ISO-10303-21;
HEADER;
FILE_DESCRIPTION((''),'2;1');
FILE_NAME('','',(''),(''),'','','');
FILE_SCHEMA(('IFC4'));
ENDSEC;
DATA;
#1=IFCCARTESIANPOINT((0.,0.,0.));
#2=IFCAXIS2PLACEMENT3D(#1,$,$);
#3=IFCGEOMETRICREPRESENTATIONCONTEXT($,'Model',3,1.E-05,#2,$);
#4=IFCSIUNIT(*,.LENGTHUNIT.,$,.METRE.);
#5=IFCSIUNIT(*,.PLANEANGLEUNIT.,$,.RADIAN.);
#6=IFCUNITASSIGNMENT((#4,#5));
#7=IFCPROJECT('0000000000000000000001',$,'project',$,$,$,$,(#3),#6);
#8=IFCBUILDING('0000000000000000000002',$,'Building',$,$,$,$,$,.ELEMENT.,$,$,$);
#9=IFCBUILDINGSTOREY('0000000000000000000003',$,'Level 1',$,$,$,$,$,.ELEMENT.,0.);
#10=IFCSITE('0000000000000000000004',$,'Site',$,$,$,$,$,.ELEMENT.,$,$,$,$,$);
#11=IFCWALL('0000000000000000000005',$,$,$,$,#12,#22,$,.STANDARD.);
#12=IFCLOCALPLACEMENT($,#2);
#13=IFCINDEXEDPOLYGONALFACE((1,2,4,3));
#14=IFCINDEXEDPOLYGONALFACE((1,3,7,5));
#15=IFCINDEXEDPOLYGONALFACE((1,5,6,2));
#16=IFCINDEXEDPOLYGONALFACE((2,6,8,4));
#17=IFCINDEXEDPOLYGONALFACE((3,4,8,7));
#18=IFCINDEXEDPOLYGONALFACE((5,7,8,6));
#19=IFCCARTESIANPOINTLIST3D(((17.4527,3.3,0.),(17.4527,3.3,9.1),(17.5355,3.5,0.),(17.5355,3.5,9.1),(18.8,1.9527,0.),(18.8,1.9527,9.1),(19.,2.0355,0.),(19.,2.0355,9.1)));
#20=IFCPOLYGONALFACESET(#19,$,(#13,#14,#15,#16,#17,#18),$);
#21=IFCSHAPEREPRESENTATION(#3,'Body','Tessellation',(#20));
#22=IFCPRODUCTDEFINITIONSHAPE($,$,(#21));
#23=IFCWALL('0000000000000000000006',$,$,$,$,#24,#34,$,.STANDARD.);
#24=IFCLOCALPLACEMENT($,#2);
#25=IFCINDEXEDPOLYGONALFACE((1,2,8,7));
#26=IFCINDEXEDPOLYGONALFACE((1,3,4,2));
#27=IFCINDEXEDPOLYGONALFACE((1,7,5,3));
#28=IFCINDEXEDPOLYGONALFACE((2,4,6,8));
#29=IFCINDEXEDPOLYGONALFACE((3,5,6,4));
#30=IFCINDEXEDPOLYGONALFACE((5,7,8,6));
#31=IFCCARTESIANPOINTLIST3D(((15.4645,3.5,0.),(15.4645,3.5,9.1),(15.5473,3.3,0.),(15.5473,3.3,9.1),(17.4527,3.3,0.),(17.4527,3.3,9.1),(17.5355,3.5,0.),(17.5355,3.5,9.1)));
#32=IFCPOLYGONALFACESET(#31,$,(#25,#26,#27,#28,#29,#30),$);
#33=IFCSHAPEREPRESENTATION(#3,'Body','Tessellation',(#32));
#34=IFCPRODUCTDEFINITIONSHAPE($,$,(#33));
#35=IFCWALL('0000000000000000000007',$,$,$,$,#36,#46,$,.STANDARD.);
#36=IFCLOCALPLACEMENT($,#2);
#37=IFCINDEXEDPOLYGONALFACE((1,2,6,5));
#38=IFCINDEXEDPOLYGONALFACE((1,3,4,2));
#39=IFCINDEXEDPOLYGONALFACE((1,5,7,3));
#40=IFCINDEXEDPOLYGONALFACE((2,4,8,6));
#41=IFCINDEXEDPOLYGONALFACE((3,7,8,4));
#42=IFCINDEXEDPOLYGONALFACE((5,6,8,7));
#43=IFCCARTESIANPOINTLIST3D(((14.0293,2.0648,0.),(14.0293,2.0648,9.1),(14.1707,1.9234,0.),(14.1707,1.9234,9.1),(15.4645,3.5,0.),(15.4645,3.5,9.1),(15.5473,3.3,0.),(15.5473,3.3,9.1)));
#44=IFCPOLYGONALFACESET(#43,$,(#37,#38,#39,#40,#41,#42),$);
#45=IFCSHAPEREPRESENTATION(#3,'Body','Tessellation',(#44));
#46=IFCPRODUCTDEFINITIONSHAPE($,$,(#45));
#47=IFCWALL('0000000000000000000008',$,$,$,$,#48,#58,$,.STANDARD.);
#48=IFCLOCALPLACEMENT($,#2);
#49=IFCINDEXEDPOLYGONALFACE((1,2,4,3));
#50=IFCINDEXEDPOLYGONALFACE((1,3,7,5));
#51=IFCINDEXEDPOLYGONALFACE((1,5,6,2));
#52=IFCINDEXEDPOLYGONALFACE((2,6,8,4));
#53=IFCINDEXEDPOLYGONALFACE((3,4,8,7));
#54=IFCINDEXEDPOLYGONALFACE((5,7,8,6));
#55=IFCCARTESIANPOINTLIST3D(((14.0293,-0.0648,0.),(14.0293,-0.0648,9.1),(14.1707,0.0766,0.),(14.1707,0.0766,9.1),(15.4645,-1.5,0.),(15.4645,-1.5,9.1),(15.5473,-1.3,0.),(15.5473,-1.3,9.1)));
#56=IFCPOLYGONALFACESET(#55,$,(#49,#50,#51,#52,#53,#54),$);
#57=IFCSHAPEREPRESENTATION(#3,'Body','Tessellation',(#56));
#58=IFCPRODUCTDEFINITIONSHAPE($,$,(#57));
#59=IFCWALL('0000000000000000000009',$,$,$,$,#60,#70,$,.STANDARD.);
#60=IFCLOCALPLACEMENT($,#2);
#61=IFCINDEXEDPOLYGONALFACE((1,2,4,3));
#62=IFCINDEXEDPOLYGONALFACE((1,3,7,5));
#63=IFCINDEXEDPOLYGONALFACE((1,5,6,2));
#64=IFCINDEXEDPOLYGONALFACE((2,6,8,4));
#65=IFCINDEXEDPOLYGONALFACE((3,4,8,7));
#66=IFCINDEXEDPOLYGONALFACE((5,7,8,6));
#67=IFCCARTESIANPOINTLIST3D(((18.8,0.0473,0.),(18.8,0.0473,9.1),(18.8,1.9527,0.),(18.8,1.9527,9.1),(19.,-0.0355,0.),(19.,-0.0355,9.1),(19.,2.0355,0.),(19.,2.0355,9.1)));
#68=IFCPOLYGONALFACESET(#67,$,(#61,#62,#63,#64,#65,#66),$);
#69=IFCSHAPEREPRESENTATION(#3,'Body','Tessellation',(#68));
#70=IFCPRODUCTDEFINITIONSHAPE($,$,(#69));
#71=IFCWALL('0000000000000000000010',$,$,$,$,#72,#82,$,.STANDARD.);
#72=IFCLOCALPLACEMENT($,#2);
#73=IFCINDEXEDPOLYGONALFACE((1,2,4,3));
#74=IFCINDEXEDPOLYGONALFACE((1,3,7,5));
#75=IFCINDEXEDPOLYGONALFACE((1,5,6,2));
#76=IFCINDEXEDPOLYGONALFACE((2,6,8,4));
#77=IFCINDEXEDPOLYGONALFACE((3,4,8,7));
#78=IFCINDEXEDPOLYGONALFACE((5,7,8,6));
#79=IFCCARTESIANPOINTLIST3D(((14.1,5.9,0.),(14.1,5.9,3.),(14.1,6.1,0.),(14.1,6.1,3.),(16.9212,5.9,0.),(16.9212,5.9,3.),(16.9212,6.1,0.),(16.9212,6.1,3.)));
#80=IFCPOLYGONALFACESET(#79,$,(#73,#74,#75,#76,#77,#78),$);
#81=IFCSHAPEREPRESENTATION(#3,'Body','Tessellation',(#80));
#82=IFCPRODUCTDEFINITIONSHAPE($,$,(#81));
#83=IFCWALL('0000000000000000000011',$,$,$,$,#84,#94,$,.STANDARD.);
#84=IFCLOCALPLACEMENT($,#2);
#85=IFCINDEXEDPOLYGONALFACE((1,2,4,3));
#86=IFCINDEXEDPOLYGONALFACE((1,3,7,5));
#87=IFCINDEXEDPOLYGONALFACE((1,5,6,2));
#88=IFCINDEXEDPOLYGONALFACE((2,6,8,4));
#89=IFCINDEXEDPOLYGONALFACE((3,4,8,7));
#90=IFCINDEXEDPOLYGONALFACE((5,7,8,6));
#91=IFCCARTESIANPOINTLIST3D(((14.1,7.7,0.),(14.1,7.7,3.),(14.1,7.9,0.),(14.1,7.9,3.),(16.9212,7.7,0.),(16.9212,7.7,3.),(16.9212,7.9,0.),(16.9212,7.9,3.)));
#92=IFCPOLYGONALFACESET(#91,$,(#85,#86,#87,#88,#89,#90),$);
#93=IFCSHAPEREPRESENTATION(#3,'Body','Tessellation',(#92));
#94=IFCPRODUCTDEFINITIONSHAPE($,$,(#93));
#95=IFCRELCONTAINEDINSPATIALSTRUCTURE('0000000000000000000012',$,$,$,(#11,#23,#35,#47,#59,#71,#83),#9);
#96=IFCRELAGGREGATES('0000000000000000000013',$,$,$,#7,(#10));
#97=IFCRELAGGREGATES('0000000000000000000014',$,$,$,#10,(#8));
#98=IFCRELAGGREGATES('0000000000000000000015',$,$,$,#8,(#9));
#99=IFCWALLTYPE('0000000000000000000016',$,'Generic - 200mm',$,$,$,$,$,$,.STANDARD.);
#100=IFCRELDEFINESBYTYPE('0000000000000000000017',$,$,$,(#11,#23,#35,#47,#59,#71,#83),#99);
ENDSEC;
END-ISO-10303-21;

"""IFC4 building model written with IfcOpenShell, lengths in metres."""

from ifc_helpers import new_model, si_unit, frame, frame_2d, origin, place, context, project, spatial, polyline, rectangle, outline, extrude, type_object, element, save


model = new_model("IFC4")

# Units and contexts
model_context = context("Model", 3, precision=1e-05, world=origin())
ifc_project = project(units=[si_unit("LENGTHUNIT", "METRE"), si_unit("PLANEANGLEUNIT", "RADIAN")], contexts=[model_context])

# Site, building, storey
site = spatial("IfcSite", under=ifc_project, Name="Site", CompositionType="ELEMENT")
building = spatial("IfcBuilding", under=site, Name="Building", CompositionType="ELEMENT")
storey = spatial("IfcBuildingStorey", under=building, Name="Level 1", CompositionType="ELEMENT", Elevation=0.0)

# Walls
wall_type = type_object("IfcWallType", Name="Generic - 200mm", PredefinedType="STANDARD")
wall_1_placement = place(None, frame((17.4941, 3.4, 0.0), z_axis=(0.0, 0.0, 1.0), x_axis=(0.707107, -0.707107, 0.0)))
element("IfcWall", 1, at=wall_1_placement, inside=storey, type_object=wall_type, PredefinedType="STANDARD", context=model_context, shape_type="SweptSolid", body=[
    extrude(outline(polyline([(0.0414, -0.1), (1.9468, -0.1), (2.0296, 0.1), (-0.0414, 0.1), (0.0414, -0.1)])), origin(), (0.0, 0.0, 1.0), 9.1),
])
wall_2_placement = place(None, frame((15.5059, 3.4, 0.0), z_axis=(0.0, 0.0, 1.0), x_axis=(1.0, 0.0, 0.0)))
element("IfcWall", 2, at=wall_2_placement, inside=storey, type_object=wall_type, PredefinedType="STANDARD", context=model_context, shape_type="SweptSolid", body=[
    extrude(outline(polyline([(0.0414, -0.1), (1.9468, -0.1), (2.0296, 0.1), (-0.0414, 0.1), (0.0414, -0.1)])), origin(), (0.0, 0.0, 1.0), 9.1),
])
wall_3_placement = place(None, frame((14.1, 1.9941, 0.0), z_axis=(0.0, 0.0, 1.0), x_axis=(0.707107, 0.707107, 0.0)))
element("IfcWall", 3, at=wall_3_placement, inside=storey, type_object=wall_type, PredefinedType="STANDARD", context=model_context, shape_type="SweptSolid", body=[
    extrude(outline(polyline([(0.0, -0.1), (1.9468, -0.1), (2.0296, 0.1), (0.0, 0.1), (0.0, -0.1)])), origin(), (0.0, 0.0, 1.0), 9.1),
])
wall_4_placement = place(None, frame((15.5059, -1.4, 0.0), z_axis=(0.0, 0.0, 1.0), x_axis=(-0.707107, 0.707107, 0.0)))
element("IfcWall", 4, at=wall_4_placement, inside=storey, type_object=wall_type, PredefinedType="STANDARD", context=model_context, shape_type="SweptSolid", body=[
    extrude(outline(polyline([(0.0414, -0.1), (1.9882, -0.1), (1.9882, 0.1), (-0.0414, 0.1), (0.0414, -0.1)])), origin(), (0.0, 0.0, 1.0), 9.1),
])

# Walls
wall_5_placement = place(None, frame((18.9, 1.9941, 0.0), z_axis=(0.0, 0.0, 1.0), x_axis=(0.0, -1.0, 0.0)))
element("IfcWall", 5, at=wall_5_placement, inside=storey, type_object=wall_type, PredefinedType="STANDARD", context=model_context, shape_type="SweptSolid", body=[
    extrude(outline(polyline([(0.0414, -0.1), (1.9468, -0.1), (2.0296, 0.1), (-0.0414, 0.1), (0.0414, -0.1)])), origin(), (0.0, 0.0, 1.0), 9.1),
])
for number, where, z_axis, x_axis in (
    (6, (16.9212, 6.0, 0.0), (0.0, 0.0, 1.0), (-1.0, 0.0, 0.0)),
    (7, (14.1, 7.8, 0.0), (0.0, 0.0, 1.0), (1.0, 0.0, 0.0)),
):
    element("IfcWall", number, at=place(None, frame(where, z_axis=z_axis, x_axis=x_axis)), inside=storey, type_object=wall_type, PredefinedType="STANDARD", context=model_context, shape_type="SweptSolid", body=[
        extrude(rectangle(XDim=2.8212, YDim=0.2, at=frame_2d((1.4106, 0.0))), origin(), (0.0, 0.0, 1.0), 3.0),
    ])

save(model, "model.ifc")
